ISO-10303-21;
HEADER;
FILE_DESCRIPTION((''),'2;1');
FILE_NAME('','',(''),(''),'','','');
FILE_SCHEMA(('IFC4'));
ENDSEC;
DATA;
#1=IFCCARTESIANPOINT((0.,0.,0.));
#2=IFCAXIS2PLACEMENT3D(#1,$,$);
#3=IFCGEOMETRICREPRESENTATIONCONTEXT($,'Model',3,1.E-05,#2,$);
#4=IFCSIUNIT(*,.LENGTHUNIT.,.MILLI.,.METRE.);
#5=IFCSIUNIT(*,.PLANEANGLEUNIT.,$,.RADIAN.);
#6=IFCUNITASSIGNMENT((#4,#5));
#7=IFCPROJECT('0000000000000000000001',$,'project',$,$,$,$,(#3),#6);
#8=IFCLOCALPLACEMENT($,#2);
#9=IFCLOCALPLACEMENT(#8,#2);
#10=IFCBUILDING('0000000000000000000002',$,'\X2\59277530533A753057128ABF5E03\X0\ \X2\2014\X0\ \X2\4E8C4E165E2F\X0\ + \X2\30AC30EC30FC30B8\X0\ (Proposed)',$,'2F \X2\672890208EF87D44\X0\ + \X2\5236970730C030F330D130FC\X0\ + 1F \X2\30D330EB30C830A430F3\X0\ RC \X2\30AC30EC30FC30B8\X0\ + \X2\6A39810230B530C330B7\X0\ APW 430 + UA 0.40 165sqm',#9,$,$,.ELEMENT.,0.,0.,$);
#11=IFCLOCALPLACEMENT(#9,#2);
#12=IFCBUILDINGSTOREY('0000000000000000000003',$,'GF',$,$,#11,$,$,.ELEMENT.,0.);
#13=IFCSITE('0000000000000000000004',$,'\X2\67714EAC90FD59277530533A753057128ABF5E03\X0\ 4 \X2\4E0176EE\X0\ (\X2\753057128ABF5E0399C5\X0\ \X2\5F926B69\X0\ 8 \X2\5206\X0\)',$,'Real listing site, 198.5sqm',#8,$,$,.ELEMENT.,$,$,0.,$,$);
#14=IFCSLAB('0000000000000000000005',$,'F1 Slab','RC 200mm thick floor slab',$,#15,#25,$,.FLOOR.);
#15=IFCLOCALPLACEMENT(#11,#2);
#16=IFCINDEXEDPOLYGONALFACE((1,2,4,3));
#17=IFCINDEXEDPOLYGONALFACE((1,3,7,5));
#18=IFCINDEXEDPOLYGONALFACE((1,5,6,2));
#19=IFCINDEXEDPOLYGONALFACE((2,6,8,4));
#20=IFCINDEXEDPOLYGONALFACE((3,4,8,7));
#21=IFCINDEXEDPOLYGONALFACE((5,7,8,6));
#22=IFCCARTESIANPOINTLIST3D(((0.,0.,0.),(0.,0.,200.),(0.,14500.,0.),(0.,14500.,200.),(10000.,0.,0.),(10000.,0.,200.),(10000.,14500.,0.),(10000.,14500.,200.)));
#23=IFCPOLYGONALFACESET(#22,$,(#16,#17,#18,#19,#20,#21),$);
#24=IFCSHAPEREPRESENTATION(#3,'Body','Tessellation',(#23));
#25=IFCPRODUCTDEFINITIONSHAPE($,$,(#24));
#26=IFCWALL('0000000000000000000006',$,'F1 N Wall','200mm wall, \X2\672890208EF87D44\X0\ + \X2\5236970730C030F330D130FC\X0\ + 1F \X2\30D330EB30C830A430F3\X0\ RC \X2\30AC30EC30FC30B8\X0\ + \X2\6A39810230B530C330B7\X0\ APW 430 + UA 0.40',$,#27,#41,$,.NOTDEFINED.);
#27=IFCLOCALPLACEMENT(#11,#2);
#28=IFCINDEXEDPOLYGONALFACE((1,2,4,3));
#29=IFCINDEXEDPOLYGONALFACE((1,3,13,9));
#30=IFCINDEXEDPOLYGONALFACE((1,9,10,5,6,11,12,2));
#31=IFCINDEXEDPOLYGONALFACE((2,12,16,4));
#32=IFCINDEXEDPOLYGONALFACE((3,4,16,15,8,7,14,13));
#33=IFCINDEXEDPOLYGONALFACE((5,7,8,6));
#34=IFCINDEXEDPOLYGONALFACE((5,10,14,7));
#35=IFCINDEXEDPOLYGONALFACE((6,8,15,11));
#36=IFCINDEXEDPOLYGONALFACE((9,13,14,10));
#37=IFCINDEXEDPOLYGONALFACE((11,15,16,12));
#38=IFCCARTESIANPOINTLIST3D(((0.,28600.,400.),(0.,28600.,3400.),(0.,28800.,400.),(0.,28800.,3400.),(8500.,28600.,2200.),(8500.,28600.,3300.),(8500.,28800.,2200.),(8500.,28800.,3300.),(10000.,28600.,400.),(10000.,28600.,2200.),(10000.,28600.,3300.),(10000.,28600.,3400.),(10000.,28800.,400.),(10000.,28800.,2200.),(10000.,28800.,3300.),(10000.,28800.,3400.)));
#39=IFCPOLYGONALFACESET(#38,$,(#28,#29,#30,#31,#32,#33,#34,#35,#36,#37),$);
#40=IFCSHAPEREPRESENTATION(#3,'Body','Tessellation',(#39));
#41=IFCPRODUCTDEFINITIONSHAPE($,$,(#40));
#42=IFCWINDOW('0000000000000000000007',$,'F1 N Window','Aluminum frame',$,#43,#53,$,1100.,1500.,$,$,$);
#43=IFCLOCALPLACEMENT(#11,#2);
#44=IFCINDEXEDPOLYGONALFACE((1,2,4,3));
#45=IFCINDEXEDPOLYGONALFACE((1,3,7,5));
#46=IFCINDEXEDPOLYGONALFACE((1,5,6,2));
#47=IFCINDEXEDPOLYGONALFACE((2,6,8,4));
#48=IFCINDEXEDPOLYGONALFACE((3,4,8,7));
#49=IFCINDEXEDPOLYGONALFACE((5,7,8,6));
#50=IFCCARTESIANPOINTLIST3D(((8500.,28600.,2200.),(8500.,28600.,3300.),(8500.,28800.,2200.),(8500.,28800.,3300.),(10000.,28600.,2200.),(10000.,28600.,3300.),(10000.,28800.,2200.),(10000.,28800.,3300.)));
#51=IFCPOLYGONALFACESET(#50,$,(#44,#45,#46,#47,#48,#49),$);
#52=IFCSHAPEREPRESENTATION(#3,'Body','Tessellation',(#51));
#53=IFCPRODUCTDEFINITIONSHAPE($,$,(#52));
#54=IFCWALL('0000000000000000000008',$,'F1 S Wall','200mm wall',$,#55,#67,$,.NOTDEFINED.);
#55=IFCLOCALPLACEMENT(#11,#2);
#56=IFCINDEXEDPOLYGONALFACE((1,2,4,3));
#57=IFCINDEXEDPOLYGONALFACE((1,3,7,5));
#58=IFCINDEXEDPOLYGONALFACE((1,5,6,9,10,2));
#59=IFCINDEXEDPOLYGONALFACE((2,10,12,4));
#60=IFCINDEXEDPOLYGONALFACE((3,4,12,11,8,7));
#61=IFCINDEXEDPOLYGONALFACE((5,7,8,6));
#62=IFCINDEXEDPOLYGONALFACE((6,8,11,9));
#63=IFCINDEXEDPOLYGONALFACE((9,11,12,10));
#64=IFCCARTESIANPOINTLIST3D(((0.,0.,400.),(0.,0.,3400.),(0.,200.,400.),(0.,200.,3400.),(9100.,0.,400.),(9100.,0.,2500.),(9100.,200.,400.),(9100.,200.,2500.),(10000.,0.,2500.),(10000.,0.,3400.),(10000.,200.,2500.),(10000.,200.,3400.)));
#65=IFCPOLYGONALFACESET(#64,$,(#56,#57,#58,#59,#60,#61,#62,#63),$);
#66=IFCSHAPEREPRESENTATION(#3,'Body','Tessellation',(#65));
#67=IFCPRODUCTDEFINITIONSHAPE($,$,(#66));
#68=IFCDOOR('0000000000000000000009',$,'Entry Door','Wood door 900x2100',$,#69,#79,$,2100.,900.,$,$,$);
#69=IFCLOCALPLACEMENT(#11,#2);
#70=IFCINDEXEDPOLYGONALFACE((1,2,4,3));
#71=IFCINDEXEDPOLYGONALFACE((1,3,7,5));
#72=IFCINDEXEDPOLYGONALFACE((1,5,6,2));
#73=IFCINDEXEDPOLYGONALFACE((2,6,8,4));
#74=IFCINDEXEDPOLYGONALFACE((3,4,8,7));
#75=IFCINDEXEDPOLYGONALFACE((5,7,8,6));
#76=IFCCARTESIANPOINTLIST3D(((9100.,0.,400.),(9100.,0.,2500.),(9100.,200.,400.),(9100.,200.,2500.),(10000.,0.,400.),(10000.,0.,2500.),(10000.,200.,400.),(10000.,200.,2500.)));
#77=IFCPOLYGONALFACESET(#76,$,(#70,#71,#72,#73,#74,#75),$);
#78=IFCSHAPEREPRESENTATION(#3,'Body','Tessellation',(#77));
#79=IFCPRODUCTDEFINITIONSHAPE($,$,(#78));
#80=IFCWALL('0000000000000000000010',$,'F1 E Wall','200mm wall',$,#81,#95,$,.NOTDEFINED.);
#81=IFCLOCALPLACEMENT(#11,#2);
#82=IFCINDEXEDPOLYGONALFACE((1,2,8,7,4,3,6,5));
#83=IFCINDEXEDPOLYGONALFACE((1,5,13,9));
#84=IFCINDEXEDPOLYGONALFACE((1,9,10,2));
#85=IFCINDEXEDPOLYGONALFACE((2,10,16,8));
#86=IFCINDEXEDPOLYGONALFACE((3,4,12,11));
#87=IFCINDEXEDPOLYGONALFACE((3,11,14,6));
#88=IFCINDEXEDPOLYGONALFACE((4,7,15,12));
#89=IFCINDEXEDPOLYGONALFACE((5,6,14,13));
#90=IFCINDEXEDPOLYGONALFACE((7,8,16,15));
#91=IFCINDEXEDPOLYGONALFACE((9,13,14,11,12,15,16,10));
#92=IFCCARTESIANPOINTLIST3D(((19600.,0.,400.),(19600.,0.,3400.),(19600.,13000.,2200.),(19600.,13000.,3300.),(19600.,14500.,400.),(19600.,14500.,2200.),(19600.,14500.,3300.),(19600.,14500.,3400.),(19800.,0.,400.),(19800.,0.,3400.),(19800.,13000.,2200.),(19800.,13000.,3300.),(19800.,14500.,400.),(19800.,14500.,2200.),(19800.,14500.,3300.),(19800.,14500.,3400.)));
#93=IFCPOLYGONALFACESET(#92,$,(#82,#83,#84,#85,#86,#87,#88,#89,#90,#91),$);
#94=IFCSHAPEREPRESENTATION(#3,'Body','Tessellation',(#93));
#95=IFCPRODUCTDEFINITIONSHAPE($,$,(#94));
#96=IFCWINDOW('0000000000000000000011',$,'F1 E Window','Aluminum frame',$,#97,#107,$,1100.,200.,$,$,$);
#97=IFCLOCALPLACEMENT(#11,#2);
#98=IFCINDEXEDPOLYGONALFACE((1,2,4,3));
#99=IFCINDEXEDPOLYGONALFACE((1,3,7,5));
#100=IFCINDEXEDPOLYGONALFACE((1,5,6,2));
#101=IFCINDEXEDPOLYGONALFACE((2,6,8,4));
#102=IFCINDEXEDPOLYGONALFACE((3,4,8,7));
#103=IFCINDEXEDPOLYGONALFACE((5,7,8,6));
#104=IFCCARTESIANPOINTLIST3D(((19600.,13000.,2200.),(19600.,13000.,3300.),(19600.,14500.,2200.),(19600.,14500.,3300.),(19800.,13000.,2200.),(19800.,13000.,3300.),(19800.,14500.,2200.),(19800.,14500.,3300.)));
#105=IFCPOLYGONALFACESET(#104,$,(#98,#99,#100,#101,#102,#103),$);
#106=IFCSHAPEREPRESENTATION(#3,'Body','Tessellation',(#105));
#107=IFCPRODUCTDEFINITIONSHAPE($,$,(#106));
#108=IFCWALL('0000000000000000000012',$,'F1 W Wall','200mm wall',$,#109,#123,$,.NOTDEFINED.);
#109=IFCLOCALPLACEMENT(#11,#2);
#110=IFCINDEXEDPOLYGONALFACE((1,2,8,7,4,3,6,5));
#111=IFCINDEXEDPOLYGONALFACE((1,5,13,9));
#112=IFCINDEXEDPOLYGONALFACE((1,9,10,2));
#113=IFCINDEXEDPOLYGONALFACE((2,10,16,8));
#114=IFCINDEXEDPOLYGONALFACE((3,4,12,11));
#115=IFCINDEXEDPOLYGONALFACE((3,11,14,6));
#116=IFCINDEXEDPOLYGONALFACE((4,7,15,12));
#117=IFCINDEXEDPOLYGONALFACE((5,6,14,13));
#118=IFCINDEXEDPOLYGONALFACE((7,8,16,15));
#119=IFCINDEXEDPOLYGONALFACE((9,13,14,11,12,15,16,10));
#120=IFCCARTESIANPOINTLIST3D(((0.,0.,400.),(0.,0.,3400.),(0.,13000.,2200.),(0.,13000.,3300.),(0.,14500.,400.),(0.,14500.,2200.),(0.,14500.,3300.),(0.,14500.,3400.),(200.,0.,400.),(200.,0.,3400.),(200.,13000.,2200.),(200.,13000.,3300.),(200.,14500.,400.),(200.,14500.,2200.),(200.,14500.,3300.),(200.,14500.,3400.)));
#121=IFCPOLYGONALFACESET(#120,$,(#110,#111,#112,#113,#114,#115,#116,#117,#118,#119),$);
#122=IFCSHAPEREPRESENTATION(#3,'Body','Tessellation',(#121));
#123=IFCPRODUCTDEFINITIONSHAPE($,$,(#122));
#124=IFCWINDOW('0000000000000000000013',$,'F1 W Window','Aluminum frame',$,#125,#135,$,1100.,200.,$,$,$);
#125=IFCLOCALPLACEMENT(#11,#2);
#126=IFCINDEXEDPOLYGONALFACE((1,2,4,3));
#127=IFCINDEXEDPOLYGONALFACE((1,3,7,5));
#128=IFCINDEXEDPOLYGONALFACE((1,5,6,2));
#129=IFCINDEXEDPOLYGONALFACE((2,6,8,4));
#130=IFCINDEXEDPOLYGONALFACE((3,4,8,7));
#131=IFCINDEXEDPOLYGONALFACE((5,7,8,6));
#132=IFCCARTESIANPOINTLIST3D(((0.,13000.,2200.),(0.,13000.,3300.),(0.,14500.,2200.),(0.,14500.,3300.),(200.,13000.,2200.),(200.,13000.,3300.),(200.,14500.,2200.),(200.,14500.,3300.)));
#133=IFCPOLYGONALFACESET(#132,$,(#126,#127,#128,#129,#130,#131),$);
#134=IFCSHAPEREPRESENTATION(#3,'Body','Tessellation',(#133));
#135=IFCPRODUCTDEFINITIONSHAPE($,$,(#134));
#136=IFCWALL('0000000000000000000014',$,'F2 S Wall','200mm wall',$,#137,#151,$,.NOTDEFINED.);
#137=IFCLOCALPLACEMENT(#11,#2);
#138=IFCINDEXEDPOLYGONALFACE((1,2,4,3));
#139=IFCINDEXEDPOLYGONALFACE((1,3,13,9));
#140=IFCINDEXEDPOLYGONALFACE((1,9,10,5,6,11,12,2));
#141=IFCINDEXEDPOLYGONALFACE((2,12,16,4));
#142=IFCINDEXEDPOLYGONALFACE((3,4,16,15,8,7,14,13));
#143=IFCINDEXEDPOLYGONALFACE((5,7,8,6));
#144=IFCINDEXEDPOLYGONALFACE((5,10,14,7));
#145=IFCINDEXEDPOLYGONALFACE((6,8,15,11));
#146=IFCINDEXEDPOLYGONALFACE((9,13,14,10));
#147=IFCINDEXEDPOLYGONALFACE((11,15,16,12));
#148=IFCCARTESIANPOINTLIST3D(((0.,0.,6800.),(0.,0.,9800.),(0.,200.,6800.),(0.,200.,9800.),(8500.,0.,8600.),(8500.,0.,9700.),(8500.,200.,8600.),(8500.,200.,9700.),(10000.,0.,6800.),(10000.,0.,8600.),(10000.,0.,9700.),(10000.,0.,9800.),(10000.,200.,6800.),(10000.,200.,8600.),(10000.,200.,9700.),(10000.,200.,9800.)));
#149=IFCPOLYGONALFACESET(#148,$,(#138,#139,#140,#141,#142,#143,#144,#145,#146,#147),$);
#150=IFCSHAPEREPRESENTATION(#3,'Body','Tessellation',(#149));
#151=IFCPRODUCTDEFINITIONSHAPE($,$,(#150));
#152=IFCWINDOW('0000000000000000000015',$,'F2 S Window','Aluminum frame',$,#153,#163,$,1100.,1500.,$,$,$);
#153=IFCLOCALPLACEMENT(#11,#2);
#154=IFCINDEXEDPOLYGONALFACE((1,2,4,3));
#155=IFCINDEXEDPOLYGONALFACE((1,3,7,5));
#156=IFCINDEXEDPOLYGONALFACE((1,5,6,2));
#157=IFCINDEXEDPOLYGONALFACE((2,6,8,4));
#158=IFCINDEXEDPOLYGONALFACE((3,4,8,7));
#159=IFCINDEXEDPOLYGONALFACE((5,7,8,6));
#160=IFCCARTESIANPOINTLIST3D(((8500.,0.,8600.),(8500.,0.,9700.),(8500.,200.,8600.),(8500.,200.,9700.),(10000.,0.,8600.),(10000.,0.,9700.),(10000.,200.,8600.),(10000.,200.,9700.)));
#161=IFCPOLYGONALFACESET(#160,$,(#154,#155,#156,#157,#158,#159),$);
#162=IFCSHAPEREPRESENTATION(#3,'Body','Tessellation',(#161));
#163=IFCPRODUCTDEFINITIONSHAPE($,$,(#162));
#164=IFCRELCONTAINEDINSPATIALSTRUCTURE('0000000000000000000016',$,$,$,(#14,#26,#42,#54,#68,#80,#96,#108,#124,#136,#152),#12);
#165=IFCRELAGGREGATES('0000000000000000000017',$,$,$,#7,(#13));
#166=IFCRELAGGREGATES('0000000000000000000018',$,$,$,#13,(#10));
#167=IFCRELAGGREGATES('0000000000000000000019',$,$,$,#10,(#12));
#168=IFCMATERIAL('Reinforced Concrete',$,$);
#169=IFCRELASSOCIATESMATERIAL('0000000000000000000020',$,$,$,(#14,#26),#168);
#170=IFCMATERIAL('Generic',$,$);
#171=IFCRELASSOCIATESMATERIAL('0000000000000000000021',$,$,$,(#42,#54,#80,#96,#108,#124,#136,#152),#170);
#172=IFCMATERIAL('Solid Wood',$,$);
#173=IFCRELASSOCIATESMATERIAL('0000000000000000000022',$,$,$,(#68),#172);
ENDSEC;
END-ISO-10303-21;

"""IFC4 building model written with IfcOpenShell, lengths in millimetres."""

from ifc_helpers import new_model, si_unit, frame, frame_2d, origin, place, context, project, spatial, rectangle, extrude, material, element, fill, save


model = new_model("IFC4")

# Units and contexts
model_context = context("Model", 3, precision=1e-05, world=origin())
ifc_project = project(units=[si_unit("LENGTHUNIT", "METRE", prefix="MILLI"), si_unit("PLANEANGLEUNIT", "RADIAN")], contexts=[model_context])

# Site, building, storey
site_placement = place(None, origin())
site = spatial("IfcSite", under=ifc_project, at=site_placement, Name="東京都大田区田園調布 4 丁目 (田園調布駅 徒歩 8 分)", ObjectType="Real listing site, 198.5sqm", CompositionType="ELEMENT", RefElevation=0.0)
building_placement = place(site_placement, origin())
building = spatial("IfcBuilding", under=site, at=building_placement, Name="大田区田園調布 — 二世帯 + ガレージ (Proposed)", ObjectType="2F 木造軸組 + 制震ダンパー + 1F ビルトイン RC ガレージ + 樹脂サッシ APW 430 + UA 0.40 165sqm", CompositionType="ELEMENT", ElevationOfRefHeight=0.0, ElevationOfTerrain=0.0)
storey_placement = place(building_placement, origin())
storey = spatial("IfcBuildingStorey", under=building, at=storey_placement, Name="GF", CompositionType="ELEMENT", Elevation=0.0)

# Slab
ifc_material_1 = material(Name="Reinforced Concrete")
slab_1_placement = place(storey_placement, origin())
element("IfcSlab", 1, at=slab_1_placement, inside=storey, material=ifc_material_1, Name="F1 Slab", Description="RC 200mm thick floor slab", PredefinedType="FLOOR", context=model_context, shape_type="SweptSolid", body=[
    extrude(rectangle(XDim=10000.0, YDim=14500.0, at=frame_2d((5000.0, 7250.0))), origin(), (0.0, 0.0, 1.0), 200.0),
])

# Wall, opening, window
wall_1_placement = place(storey_placement, frame((0.0, 14300.0, 200.0)))
wall_1 = element("IfcWall", 2, at=wall_1_placement, inside=storey, material=ifc_material_1, Name="F1 N Wall", Description="200mm wall, 木造軸組 + 制震ダンパー + 1F ビルトイン RC ガレージ + 樹脂サッシ APW 430 + UA 0.40", PredefinedType="NOTDEFINED", context=model_context, shape_type="SweptSolid", body=[
    extrude(rectangle(XDim=10000.0, YDim=200.0, at=frame_2d((5000.0, 100.0))), frame((0.0, 14300.0, 200.0)), (0.0, 0.0, 1.0), 3000.0),
])
opening_1_placement = place(storey_placement, frame((4250.0, 14300.0, 1100.0)))
opening_1 = element("IfcOpeningElement", 3, at=opening_1_placement, cuts=wall_1, PredefinedType="NOTDEFINED", context=model_context, shape_type="SweptSolid", body=[
    extrude(rectangle(XDim=1500.0, YDim=200.0, at=frame_2d((750.0, 100.0))), frame((4250.0, 14300.0, 1100.0)), (0.0, 0.0, 1.0), 1100.0),
])
ifc_material_2 = material(Name="Generic")
window_1_placement = place(storey_placement, frame((4250.0, 14300.0, 1100.0)))
window_1 = element("IfcWindow", 4, at=window_1_placement, inside=storey, material=ifc_material_2, Name="F1 N Window", Description="Aluminum frame", OverallHeight=1100.0, OverallWidth=1500.0, context=model_context, shape_type="SweptSolid", body=[
    extrude(rectangle(XDim=1500.0, YDim=200.0, at=frame_2d((750.0, 100.0))), frame((4250.0, 14300.0, 1100.0)), (0.0, 0.0, 1.0), 1100.0),
])
fill(opening_1, window_1)

# Wall, opening, door
wall_2_placement = place(storey_placement, frame((0.0, 0.0, 200.0)))
wall_2 = element("IfcWall", 5, at=wall_2_placement, inside=storey, material=ifc_material_2, Name="F1 S Wall", Description="200mm wall", PredefinedType="NOTDEFINED", context=model_context, shape_type="SweptSolid", body=[
    extrude(rectangle(XDim=10000.0, YDim=200.0, at=frame_2d((5000.0, 100.0))), frame((0.0, 0.0, 200.0)), (0.0, 0.0, 1.0), 3000.0),
])
opening_2_placement = place(storey_placement, frame((4550.0, 0.0, 200.0)))
opening_2 = element("IfcOpeningElement", 6, at=opening_2_placement, cuts=wall_2, PredefinedType="NOTDEFINED", context=model_context, shape_type="SweptSolid", body=[
    extrude(rectangle(XDim=900.0, YDim=200.0, at=frame_2d((450.0, 100.0))), frame((4550.0, 0.0, 200.0)), (0.0, 0.0, 1.0), 2100.0),
])
ifc_material_3 = material(Name="Solid Wood")
door_placement = place(storey_placement, frame((4550.0, 0.0, 200.0)))
door = element("IfcDoor", 7, at=door_placement, inside=storey, material=ifc_material_3, Name="Entry Door", Description="Wood door 900x2100", OverallHeight=2100.0, OverallWidth=900.0, context=model_context, shape_type="SweptSolid", body=[
    extrude(rectangle(XDim=900.0, YDim=200.0, at=frame_2d((450.0, 100.0))), frame((4550.0, 0.0, 200.0)), (0.0, 0.0, 1.0), 2100.0),
])
fill(opening_2, door)

# Walls, openings, windows
wall_3_placement = place(storey_placement, frame((9800.0, 0.0, 200.0)))
wall_3 = element("IfcWall", 8, at=wall_3_placement, inside=storey, material=ifc_material_2, Name="F1 E Wall", Description="200mm wall", PredefinedType="NOTDEFINED", context=model_context, shape_type="SweptSolid", body=[
    extrude(rectangle(XDim=200.0, YDim=14500.0, at=frame_2d((100.0, 7250.0))), frame((9800.0, 0.0, 200.0)), (0.0, 0.0, 1.0), 3000.0),
])
opening_3_placement = place(storey_placement, frame((9800.0, 6500.0, 1100.0)))
opening_3 = element("IfcOpeningElement", 9, at=opening_3_placement, cuts=wall_3, PredefinedType="NOTDEFINED", context=model_context, shape_type="SweptSolid", body=[
    extrude(rectangle(XDim=200.0, YDim=1500.0, at=frame_2d((100.0, 750.0))), frame((9800.0, 6500.0, 1100.0)), (0.0, 0.0, 1.0), 1100.0),
])
window_2_placement = place(storey_placement, frame((9800.0, 6500.0, 1100.0)))
window_2 = element("IfcWindow", 10, at=window_2_placement, inside=storey, material=ifc_material_2, Name="F1 E Window", Description="Aluminum frame", OverallHeight=1100.0, OverallWidth=200.0, context=model_context, shape_type="SweptSolid", body=[
    extrude(rectangle(XDim=200.0, YDim=1500.0, at=frame_2d((100.0, 750.0))), frame((9800.0, 6500.0, 1100.0)), (0.0, 0.0, 1.0), 1100.0),
])
fill(opening_3, window_2)
wall_4_placement = place(storey_placement, frame((0.0, 0.0, 200.0)))
wall_4 = element("IfcWall", 11, at=wall_4_placement, inside=storey, material=ifc_material_2, Name="F1 W Wall", Description="200mm wall", PredefinedType="NOTDEFINED", context=model_context, shape_type="SweptSolid", body=[
    extrude(rectangle(XDim=200.0, YDim=14500.0, at=frame_2d((100.0, 7250.0))), frame((0.0, 0.0, 200.0)), (0.0, 0.0, 1.0), 3000.0),
])
opening_4_placement = place(storey_placement, frame((0.0, 6500.0, 1100.0)))
opening_4 = element("IfcOpeningElement", 12, at=opening_4_placement, cuts=wall_4, PredefinedType="NOTDEFINED", context=model_context, shape_type="SweptSolid", body=[
    extrude(rectangle(XDim=200.0, YDim=1500.0, at=frame_2d((100.0, 750.0))), frame((0.0, 6500.0, 1100.0)), (0.0, 0.0, 1.0), 1100.0),
])
window_3_placement = place(storey_placement, frame((0.0, 6500.0, 1100.0)))
window_3 = element("IfcWindow", 13, at=window_3_placement, inside=storey, material=ifc_material_2, Name="F1 W Window", Description="Aluminum frame", OverallHeight=1100.0, OverallWidth=200.0, context=model_context, shape_type="SweptSolid", body=[
    extrude(rectangle(XDim=200.0, YDim=1500.0, at=frame_2d((100.0, 750.0))), frame((0.0, 6500.0, 1100.0)), (0.0, 0.0, 1.0), 1100.0),
])
fill(opening_4, window_3)
wall_5_placement = place(storey_placement, frame((0.0, 0.0, 3400.0)))
wall_5 = element("IfcWall", 14, at=wall_5_placement, inside=storey, material=ifc_material_2, Name="F2 S Wall", Description="200mm wall", PredefinedType="NOTDEFINED", context=model_context, shape_type="SweptSolid", body=[
    extrude(rectangle(XDim=10000.0, YDim=200.0, at=frame_2d((5000.0, 100.0))), frame((0.0, 0.0, 3400.0)), (0.0, 0.0, 1.0), 3000.0),
])
opening_5_placement = place(storey_placement, frame((4250.0, 0.0, 4300.0)))
opening_5 = element("IfcOpeningElement", 15, at=opening_5_placement, cuts=wall_5, PredefinedType="NOTDEFINED", context=model_context, shape_type="SweptSolid", body=[
    extrude(rectangle(XDim=1500.0, YDim=200.0, at=frame_2d((750.0, 100.0))), frame((4250.0, 0.0, 4300.0)), (0.0, 0.0, 1.0), 1100.0),
])
window_4_placement = place(storey_placement, frame((4250.0, 0.0, 4300.0)))
window_4 = element("IfcWindow", 16, at=window_4_placement, inside=storey, material=ifc_material_2, Name="F2 S Window", Description="Aluminum frame", OverallHeight=1100.0, OverallWidth=1500.0, context=model_context, shape_type="SweptSolid", body=[
    extrude(rectangle(XDim=1500.0, YDim=200.0, at=frame_2d((750.0, 100.0))), frame((4250.0, 0.0, 4300.0)), (0.0, 0.0, 1.0), 1100.0),
])
fill(opening_5, window_4)

save(model, "model.ifc")
